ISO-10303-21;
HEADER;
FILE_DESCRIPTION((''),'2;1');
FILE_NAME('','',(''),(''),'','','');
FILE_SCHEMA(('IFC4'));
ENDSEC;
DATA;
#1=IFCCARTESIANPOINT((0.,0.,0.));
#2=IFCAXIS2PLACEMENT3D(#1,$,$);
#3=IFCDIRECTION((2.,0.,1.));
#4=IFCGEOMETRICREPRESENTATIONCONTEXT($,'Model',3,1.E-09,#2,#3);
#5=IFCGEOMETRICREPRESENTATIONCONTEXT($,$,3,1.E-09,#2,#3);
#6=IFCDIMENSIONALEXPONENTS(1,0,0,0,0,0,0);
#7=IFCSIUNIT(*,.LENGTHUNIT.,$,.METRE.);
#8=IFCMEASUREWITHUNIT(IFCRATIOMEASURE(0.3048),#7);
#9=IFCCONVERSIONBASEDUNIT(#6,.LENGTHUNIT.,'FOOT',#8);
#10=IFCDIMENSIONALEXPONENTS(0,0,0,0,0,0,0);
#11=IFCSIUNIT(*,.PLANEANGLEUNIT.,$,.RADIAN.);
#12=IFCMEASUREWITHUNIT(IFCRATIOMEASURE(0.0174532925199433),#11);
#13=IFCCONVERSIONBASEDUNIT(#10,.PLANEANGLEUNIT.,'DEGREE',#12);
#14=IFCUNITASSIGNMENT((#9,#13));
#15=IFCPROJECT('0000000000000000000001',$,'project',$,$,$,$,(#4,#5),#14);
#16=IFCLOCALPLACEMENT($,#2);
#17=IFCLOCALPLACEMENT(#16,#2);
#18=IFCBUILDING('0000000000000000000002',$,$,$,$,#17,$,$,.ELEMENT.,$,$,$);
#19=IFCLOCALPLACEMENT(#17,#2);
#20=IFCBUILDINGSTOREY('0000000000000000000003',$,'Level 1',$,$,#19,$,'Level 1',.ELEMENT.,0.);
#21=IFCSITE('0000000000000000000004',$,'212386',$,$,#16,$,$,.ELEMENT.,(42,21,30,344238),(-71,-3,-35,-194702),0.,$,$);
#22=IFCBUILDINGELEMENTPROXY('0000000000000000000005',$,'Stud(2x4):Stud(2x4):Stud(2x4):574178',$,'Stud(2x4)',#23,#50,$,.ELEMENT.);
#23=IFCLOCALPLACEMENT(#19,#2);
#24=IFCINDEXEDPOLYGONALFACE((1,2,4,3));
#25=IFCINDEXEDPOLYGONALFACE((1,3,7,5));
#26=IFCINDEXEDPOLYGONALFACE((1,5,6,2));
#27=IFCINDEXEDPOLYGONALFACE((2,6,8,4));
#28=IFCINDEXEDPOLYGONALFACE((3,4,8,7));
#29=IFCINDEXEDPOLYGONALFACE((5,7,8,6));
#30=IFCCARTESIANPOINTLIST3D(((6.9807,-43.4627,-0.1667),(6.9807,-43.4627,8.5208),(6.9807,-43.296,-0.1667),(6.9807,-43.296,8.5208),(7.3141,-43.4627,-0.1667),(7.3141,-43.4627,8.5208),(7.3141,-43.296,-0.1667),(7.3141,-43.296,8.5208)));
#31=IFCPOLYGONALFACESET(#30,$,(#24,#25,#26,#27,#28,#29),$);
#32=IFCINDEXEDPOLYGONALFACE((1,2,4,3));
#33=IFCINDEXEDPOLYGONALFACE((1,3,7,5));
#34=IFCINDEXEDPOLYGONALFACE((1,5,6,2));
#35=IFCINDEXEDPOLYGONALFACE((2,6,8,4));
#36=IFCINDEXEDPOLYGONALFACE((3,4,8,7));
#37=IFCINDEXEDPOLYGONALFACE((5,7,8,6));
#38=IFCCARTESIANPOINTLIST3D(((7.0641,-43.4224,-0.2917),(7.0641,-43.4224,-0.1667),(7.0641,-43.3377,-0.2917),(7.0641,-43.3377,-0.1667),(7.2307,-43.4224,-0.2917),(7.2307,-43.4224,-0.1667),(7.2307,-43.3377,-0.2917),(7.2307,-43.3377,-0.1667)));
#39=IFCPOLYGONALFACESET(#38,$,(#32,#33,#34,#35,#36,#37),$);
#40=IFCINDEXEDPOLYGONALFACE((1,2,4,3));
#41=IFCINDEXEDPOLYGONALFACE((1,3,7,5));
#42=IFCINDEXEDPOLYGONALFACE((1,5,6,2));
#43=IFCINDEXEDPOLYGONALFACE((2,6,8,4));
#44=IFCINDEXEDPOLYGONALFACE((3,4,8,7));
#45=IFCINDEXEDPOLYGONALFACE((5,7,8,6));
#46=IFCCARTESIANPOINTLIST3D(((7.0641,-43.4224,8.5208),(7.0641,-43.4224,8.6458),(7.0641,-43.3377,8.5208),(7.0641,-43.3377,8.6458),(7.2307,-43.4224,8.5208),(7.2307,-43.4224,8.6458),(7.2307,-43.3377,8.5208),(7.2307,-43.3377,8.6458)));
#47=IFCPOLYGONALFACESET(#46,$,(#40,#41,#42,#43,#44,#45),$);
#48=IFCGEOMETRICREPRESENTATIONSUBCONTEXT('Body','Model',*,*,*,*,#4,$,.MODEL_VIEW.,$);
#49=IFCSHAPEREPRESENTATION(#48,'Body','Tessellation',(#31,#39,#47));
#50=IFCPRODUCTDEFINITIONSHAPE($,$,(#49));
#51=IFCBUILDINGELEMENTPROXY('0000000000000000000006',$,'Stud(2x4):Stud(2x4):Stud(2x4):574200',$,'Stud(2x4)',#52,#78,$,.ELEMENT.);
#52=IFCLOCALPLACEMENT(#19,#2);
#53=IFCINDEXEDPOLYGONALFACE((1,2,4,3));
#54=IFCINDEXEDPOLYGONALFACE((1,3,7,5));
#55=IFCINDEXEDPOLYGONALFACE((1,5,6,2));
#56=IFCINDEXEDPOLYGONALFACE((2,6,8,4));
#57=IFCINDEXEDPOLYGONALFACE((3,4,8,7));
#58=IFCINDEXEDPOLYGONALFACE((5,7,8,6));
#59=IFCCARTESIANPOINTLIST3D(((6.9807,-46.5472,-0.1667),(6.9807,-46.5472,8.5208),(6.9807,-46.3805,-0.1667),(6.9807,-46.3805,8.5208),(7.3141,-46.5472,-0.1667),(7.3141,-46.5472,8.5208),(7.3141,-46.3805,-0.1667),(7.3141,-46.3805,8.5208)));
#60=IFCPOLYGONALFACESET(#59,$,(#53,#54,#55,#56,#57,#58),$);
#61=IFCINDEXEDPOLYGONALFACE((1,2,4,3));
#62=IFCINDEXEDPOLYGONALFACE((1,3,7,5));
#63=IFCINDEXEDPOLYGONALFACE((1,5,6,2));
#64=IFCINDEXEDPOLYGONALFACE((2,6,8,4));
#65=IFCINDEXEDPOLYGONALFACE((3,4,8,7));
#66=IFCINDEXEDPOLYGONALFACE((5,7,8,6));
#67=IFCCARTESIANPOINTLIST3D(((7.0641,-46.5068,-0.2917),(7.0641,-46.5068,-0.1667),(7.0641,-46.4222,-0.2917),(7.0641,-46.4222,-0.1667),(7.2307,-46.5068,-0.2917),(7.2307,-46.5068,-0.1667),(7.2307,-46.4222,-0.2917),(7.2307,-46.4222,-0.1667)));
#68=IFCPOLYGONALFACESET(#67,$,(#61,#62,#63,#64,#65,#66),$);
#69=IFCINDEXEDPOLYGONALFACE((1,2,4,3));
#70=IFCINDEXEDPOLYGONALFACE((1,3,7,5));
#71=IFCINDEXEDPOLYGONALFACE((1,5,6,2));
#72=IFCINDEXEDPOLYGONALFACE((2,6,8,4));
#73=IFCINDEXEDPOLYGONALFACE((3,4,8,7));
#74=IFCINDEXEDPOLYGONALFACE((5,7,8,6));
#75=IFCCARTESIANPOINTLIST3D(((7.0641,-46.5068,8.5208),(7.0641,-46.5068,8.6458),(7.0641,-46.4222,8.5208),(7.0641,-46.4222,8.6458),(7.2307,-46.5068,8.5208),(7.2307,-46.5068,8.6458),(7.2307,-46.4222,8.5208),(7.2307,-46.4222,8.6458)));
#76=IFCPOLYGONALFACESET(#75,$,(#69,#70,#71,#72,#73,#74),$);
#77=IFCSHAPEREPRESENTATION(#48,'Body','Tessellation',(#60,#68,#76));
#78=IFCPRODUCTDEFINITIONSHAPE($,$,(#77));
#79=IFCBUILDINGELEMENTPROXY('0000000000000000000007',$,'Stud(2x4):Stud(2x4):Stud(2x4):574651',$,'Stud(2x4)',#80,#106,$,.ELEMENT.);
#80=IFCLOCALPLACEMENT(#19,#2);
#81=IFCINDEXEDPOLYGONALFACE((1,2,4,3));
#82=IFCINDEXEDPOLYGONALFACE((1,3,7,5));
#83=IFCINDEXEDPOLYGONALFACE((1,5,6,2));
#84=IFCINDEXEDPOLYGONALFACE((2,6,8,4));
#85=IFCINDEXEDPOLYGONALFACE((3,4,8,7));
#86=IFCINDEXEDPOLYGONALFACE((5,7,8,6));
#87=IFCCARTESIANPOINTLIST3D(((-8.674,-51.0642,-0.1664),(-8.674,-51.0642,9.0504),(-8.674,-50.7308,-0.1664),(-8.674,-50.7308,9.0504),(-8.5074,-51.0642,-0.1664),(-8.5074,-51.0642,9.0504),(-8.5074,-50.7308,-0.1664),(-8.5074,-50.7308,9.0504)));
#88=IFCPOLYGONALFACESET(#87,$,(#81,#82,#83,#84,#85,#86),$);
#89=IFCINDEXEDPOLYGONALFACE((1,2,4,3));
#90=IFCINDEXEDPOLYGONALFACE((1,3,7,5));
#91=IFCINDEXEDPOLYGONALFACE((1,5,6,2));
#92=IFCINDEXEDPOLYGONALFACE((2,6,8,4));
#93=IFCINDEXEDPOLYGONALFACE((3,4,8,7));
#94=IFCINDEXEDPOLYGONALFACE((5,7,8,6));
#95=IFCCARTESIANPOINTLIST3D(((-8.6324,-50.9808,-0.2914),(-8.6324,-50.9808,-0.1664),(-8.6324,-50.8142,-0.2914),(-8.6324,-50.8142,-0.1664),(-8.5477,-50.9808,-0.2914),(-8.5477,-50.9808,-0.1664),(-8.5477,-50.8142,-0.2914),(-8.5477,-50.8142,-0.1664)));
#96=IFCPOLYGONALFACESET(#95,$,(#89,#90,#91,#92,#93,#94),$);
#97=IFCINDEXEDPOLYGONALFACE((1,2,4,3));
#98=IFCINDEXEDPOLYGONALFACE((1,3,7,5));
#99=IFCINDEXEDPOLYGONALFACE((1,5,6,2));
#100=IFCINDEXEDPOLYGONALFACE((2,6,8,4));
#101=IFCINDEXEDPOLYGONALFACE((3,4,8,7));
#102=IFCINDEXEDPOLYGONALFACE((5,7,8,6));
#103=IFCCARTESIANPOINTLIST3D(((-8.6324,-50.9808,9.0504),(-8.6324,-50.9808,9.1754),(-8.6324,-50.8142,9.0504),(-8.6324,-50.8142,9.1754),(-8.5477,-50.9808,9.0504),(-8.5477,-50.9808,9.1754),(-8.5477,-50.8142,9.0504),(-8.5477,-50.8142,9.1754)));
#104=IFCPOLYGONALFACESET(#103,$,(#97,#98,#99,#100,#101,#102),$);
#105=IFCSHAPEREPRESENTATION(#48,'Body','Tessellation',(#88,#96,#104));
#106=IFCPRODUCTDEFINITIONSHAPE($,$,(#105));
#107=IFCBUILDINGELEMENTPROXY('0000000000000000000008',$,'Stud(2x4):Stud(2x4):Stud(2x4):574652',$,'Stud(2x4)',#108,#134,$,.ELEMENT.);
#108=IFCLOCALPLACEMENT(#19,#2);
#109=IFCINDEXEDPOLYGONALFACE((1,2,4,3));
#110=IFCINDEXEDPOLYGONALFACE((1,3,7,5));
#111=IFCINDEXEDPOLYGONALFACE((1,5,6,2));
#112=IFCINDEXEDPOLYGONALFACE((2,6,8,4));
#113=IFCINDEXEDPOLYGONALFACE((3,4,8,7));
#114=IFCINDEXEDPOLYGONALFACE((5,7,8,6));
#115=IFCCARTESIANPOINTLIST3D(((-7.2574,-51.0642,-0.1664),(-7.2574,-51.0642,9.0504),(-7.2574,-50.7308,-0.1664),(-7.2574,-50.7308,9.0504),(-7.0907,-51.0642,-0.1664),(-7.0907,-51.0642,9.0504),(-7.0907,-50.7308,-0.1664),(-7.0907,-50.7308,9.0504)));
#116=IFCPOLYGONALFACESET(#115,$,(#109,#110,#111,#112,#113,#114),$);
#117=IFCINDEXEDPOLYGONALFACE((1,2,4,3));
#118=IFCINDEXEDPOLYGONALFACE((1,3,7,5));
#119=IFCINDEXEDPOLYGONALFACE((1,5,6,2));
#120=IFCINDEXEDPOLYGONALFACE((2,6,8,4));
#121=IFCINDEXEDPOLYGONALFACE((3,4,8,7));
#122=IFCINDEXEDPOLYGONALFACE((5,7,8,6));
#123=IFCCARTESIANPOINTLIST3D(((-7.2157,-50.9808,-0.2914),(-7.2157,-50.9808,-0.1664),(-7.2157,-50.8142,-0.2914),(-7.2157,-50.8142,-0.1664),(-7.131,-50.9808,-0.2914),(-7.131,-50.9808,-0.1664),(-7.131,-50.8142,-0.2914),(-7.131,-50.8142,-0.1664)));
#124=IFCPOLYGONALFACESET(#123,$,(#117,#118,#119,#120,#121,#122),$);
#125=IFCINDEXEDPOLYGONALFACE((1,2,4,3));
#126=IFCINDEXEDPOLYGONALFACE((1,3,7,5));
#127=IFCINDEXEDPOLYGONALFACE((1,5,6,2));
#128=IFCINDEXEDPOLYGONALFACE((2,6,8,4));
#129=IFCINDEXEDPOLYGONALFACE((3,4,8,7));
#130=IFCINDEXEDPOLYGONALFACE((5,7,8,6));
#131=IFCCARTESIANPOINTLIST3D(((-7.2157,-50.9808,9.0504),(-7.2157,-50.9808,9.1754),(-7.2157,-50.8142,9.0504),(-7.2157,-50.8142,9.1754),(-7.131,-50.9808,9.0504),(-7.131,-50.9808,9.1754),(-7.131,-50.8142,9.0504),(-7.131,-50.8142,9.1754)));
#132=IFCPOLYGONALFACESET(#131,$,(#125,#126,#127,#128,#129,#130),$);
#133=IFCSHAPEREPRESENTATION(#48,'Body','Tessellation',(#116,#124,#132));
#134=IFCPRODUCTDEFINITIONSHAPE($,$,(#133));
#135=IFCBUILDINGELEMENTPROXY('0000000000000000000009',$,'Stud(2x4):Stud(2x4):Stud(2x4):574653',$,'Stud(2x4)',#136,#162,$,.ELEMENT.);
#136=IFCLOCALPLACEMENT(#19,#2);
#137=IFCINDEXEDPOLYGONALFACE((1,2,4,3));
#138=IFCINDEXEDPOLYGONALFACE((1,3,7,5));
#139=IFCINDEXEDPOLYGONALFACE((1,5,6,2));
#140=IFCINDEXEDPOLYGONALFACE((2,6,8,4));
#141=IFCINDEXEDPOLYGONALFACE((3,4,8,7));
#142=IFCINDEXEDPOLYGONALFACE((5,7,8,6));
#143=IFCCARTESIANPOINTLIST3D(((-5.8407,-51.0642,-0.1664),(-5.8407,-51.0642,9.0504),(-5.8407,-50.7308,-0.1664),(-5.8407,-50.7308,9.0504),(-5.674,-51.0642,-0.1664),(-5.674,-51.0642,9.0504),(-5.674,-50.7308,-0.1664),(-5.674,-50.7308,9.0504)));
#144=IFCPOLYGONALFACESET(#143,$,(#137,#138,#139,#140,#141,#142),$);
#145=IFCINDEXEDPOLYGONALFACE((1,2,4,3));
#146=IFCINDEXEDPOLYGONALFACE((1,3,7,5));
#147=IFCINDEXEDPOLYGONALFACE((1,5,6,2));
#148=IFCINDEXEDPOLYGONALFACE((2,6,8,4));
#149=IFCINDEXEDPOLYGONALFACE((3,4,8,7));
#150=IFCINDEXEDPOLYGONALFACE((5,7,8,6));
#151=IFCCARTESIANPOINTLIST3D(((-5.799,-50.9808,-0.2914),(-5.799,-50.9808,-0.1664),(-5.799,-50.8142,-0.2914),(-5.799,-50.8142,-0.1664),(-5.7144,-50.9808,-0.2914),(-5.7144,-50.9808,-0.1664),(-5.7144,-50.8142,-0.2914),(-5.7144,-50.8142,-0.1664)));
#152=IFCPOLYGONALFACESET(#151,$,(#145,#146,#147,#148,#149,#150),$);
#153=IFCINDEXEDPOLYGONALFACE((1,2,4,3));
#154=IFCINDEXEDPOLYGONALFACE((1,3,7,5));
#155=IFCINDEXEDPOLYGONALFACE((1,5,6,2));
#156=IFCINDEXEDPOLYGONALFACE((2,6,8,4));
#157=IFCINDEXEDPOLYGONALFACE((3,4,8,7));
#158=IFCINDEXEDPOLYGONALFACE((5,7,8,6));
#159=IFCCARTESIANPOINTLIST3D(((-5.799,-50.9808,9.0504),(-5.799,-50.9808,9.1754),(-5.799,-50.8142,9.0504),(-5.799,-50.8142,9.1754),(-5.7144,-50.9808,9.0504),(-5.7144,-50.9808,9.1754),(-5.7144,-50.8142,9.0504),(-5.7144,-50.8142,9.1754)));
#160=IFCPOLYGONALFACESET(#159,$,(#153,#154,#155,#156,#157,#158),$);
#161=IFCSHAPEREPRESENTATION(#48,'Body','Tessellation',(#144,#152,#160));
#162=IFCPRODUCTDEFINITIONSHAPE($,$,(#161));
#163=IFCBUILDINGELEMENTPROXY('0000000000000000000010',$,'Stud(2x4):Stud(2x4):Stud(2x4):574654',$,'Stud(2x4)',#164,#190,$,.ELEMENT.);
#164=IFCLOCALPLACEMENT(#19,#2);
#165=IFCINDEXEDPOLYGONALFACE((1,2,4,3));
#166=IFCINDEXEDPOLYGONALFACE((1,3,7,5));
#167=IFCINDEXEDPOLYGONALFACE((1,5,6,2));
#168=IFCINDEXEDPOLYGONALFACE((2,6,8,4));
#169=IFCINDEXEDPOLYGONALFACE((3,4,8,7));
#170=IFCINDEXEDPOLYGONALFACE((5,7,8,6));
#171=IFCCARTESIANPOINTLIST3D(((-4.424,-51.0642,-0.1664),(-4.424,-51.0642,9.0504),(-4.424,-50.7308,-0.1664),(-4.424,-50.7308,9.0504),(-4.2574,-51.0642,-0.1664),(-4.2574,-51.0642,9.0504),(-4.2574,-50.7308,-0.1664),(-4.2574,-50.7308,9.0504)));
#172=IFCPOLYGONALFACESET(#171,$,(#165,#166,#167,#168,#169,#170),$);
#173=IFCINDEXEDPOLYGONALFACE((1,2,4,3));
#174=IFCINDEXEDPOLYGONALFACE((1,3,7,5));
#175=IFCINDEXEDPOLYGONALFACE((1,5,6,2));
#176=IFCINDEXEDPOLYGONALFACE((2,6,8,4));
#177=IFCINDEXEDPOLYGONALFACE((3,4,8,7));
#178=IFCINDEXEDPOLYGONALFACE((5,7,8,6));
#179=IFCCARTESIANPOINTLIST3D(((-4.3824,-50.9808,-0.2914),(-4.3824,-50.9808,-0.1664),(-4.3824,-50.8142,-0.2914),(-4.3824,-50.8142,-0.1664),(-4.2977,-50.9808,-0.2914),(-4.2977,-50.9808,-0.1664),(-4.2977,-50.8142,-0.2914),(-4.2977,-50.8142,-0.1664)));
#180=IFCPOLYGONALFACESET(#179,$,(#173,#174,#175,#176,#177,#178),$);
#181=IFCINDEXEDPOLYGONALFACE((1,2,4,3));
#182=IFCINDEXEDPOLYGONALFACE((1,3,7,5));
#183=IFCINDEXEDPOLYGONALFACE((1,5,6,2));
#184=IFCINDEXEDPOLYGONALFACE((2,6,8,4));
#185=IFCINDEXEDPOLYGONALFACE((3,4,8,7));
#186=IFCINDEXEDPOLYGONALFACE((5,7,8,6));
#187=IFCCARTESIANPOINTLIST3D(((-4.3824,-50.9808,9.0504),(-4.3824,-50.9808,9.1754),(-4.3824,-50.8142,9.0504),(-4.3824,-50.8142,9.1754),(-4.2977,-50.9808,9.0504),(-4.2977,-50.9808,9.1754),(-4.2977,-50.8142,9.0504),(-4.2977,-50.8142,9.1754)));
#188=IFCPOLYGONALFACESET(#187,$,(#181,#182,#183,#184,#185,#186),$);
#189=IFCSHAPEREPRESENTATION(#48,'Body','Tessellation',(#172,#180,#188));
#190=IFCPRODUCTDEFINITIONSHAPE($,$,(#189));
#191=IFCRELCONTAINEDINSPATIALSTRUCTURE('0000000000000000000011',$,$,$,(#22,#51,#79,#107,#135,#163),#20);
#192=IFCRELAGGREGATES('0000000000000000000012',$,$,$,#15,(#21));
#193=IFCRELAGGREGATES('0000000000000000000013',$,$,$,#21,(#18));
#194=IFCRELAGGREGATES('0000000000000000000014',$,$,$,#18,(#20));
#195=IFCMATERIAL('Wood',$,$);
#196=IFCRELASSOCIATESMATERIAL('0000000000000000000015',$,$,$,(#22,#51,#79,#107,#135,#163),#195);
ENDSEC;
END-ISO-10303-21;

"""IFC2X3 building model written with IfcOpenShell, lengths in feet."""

from ifc_helpers import new_model, entity, si_unit, converted_unit, direction, frame, frame_2d, origin, place, context, subcontext, project, spatial, rectangle, extrude, source, transform, mapped, material, element, save


model = new_model("IFC2X3")

# Units and contexts
model_context = context("Model", 3, precision=1e-09, world=origin(), true_north=direction((2.0, 0.0, 1.0)))
context_of_model = context(None, 3, precision=1e-09, world=origin(), true_north=direction((2.0, 0.0, 1.0)))
body_context = subcontext(model_context, "Body", "Model", "MODEL_VIEW")
ifc_project = project(units=[converted_unit("LENGTHUNIT", "FOOT", entity("IfcRatioMeasure", 0.3048), si_unit("LENGTHUNIT", "METRE"), dimensions=[1, 0, 0, 0, 0, 0, 0]), converted_unit("PLANEANGLEUNIT", "DEGREE", entity("IfcRatioMeasure", 0.0174532925199433), si_unit("PLANEANGLEUNIT", "RADIAN"), dimensions=[0, 0, 0, 0, 0, 0, 0])], contexts=[model_context, context_of_model])

# Site, building, storey
site_placement = place(None, origin())
site = spatial("IfcSite", under=ifc_project, at=site_placement, Name="212386", CompositionType="ELEMENT", RefLatitude=(42, 21, 30, 344238), RefLongitude=(-71, -3, -35, -194702), RefElevation=0.0)
building_placement = place(site_placement, origin())
building = spatial("IfcBuilding", under=site, at=building_placement, CompositionType="ELEMENT")
storey_placement = place(building_placement, origin())
storey = spatial("IfcBuildingStorey", under=building, at=storey_placement, Name="Level 1", LongName="Level 1", CompositionType="ELEMENT", Elevation=0.0)

# Building element proxies
ifc_material = material(Name="Wood")
shared_shape_1 = source(origin(), body_context, "Body", "SweptSolid", [
    extrude(rectangle(XDim=0.1667, YDim=0.3333, at=frame_2d((0.0, 0.0), x_axis=(1.0, 0.0))), frame((7.1474, -43.3794, -0.1667), z_axis=(0.0, 0.0, 1.0), x_axis=(0.0, -1.0, 0.0)), (0.0, 0.0, 1.0), 8.6875),
    extrude(rectangle(XDim=0.0847, YDim=0.1667, at=frame_2d((0.0, 0.0), x_axis=(1.0, 0.0))), frame((7.1474, -43.38, -0.2917), z_axis=(0.0, 0.0, 1.0), x_axis=(0.0, -1.0, 0.0)), (0.0, 0.0, 1.0), 0.125),
    extrude(rectangle(XDim=0.1667, YDim=0.0847, at=frame_2d((0.0, 0.0), x_axis=(1.0, 0.0))), frame((7.1474, -43.38, 8.5208), z_axis=(0.0, 0.0, 1.0), x_axis=(-1.0, 0.0, 0.0)), (0.0, 0.0, 1.0), 0.125),
])
proxy_1_placement = place(storey_placement, origin())
element("IfcBuildingElementProxy", 1, at=proxy_1_placement, inside=storey, material=ifc_material, Name="Stud(2x4):Stud(2x4):Stud(2x4):574178", ObjectType="Stud(2x4)", CompositionType="ELEMENT", context=body_context, shape_type="MappedRepresentation", body=[
    mapped(shared_shape_1, transform((0.0, 0.0, 0.0), scale=1.0)),
])
shared_shape_2 = source(origin(), body_context, "Body", "SweptSolid", [
    extrude(rectangle(XDim=0.1667, YDim=0.3333, at=frame_2d((0.0, 0.0), x_axis=(1.0, 0.0))), frame((7.1474, -46.4638, -0.1667), z_axis=(0.0, 0.0, 1.0), x_axis=(0.0, -1.0, 0.0)), (0.0, 0.0, 1.0), 8.6875),
    extrude(rectangle(XDim=0.0847, YDim=0.1667, at=frame_2d((0.0, 0.0), x_axis=(1.0, 0.0))), frame((7.1474, -46.4645, -0.2917), z_axis=(0.0, 0.0, 1.0), x_axis=(0.0, -1.0, 0.0)), (0.0, 0.0, 1.0), 0.125),
    extrude(rectangle(XDim=0.1667, YDim=0.0847, at=frame_2d((0.0, 0.0), x_axis=(1.0, 0.0))), frame((7.1474, -46.4645, 8.5208), z_axis=(0.0, 0.0, 1.0), x_axis=(-1.0, 0.0, 0.0)), (0.0, 0.0, 1.0), 0.125),
])
proxy_2_placement = place(storey_placement, origin())
element("IfcBuildingElementProxy", 2, at=proxy_2_placement, inside=storey, material=ifc_material, Name="Stud(2x4):Stud(2x4):Stud(2x4):574200", ObjectType="Stud(2x4)", CompositionType="ELEMENT", context=body_context, shape_type="MappedRepresentation", body=[
    mapped(shared_shape_2, transform((0.0, 0.0, 0.0), scale=1.0)),
])
shared_shape_3 = source(origin(), body_context, "Body", "SweptSolid", [
    extrude(rectangle(XDim=0.3333, YDim=0.1667, at=frame_2d((0.0, 0.0), x_axis=(1.0, 0.0))), frame((-8.5907, -50.8975, -0.1664), z_axis=(0.0, 0.0, 1.0), x_axis=(0.0, -1.0, 0.0)), (0.0, 0.0, 1.0), 9.2168),
    extrude(rectangle(XDim=0.1667, YDim=0.0847, at=frame_2d((0.0, 0.0), x_axis=(1.0, 0.0))), frame((-8.59, -50.8975, -0.2914), z_axis=(0.0, 0.0, 1.0), x_axis=(0.0, -1.0, 0.0)), (0.0, 0.0, 1.0), 0.125),
    extrude(rectangle(XDim=0.0847, YDim=0.1667, at=frame_2d((0.0, 0.0), x_axis=(1.0, 0.0))), frame((-8.59, -50.8975, 9.0504)), (0.0, 0.0, 1.0), 0.125),
])
proxy_3_placement = place(storey_placement, origin())
element("IfcBuildingElementProxy", 3, at=proxy_3_placement, inside=storey, material=ifc_material, Name="Stud(2x4):Stud(2x4):Stud(2x4):574651", ObjectType="Stud(2x4)", CompositionType="ELEMENT", context=body_context, shape_type="MappedRepresentation", body=[
    mapped(shared_shape_3, transform((0.0, 0.0, 0.0), scale=1.0)),
])
shared_shape_4 = source(origin(), body_context, "Body", "SweptSolid", [
    extrude(rectangle(XDim=0.3333, YDim=0.1667, at=frame_2d((0.0, 0.0), x_axis=(1.0, 0.0))), frame((-7.174, -50.8975, -0.1664), z_axis=(0.0, 0.0, 1.0), x_axis=(0.0, -1.0, 0.0)), (0.0, 0.0, 1.0), 9.2168),
    extrude(rectangle(XDim=0.1667, YDim=0.0847, at=frame_2d((0.0, 0.0), x_axis=(1.0, 0.0))), frame((-7.1734, -50.8975, -0.2914), z_axis=(0.0, 0.0, 1.0), x_axis=(0.0, -1.0, 0.0)), (0.0, 0.0, 1.0), 0.125),
    extrude(rectangle(XDim=0.0847, YDim=0.1667, at=frame_2d((0.0, 0.0), x_axis=(1.0, 0.0))), frame((-7.1734, -50.8975, 9.0504)), (0.0, 0.0, 1.0), 0.125),
])
proxy_4_placement = place(storey_placement, origin())
element("IfcBuildingElementProxy", 4, at=proxy_4_placement, inside=storey, material=ifc_material, Name="Stud(2x4):Stud(2x4):Stud(2x4):574652", ObjectType="Stud(2x4)", CompositionType="ELEMENT", context=body_context, shape_type="MappedRepresentation", body=[
    mapped(shared_shape_4, transform((0.0, 0.0, 0.0), scale=1.0)),
])
shared_shape_5 = source(origin(), body_context, "Body", "SweptSolid", [
    extrude(rectangle(XDim=0.3333, YDim=0.1667, at=frame_2d((0.0, 0.0), x_axis=(1.0, 0.0))), frame((-5.7574, -50.8975, -0.1664), z_axis=(0.0, 0.0, 1.0), x_axis=(0.0, -1.0, 0.0)), (0.0, 0.0, 1.0), 9.2168),
    extrude(rectangle(XDim=0.1667, YDim=0.0847, at=frame_2d((0.0, 0.0), x_axis=(1.0, 0.0))), frame((-5.7567, -50.8975, -0.2914), z_axis=(0.0, 0.0, 1.0), x_axis=(0.0, -1.0, 0.0)), (0.0, 0.0, 1.0), 0.125),
    extrude(rectangle(XDim=0.0847, YDim=0.1667, at=frame_2d((0.0, 0.0), x_axis=(1.0, 0.0))), frame((-5.7567, -50.8975, 9.0504)), (0.0, 0.0, 1.0), 0.125),
])
proxy_5_placement = place(storey_placement, origin())
element("IfcBuildingElementProxy", 5, at=proxy_5_placement, inside=storey, material=ifc_material, Name="Stud(2x4):Stud(2x4):Stud(2x4):574653", ObjectType="Stud(2x4)", CompositionType="ELEMENT", context=body_context, shape_type="MappedRepresentation", body=[
    mapped(shared_shape_5, transform((0.0, 0.0, 0.0), scale=1.0)),
])
shared_shape_6 = source(origin(), body_context, "Body", "SweptSolid", [
    extrude(rectangle(XDim=0.3333, YDim=0.1667, at=frame_2d((0.0, 0.0), x_axis=(1.0, 0.0))), frame((-4.3407, -50.8975, -0.1664), z_axis=(0.0, 0.0, 1.0), x_axis=(0.0, -1.0, 0.0)), (0.0, 0.0, 1.0), 9.2168),
    extrude(rectangle(XDim=0.1667, YDim=0.0847, at=frame_2d((0.0, 0.0), x_axis=(1.0, 0.0))), frame((-4.34, -50.8975, -0.2914), z_axis=(0.0, 0.0, 1.0), x_axis=(0.0, -1.0, 0.0)), (0.0, 0.0, 1.0), 0.125),
    extrude(rectangle(XDim=0.0847, YDim=0.1667, at=frame_2d((0.0, 0.0), x_axis=(1.0, 0.0))), frame((-4.34, -50.8975, 9.0504)), (0.0, 0.0, 1.0), 0.125),
])
proxy_6_placement = place(storey_placement, origin())
element("IfcBuildingElementProxy", 6, at=proxy_6_placement, inside=storey, material=ifc_material, Name="Stud(2x4):Stud(2x4):Stud(2x4):574654", ObjectType="Stud(2x4)", CompositionType="ELEMENT", context=body_context, shape_type="MappedRepresentation", body=[
    mapped(shared_shape_6, transform((0.0, 0.0, 0.0), scale=1.0)),
])

save(model, "model.ifc")
